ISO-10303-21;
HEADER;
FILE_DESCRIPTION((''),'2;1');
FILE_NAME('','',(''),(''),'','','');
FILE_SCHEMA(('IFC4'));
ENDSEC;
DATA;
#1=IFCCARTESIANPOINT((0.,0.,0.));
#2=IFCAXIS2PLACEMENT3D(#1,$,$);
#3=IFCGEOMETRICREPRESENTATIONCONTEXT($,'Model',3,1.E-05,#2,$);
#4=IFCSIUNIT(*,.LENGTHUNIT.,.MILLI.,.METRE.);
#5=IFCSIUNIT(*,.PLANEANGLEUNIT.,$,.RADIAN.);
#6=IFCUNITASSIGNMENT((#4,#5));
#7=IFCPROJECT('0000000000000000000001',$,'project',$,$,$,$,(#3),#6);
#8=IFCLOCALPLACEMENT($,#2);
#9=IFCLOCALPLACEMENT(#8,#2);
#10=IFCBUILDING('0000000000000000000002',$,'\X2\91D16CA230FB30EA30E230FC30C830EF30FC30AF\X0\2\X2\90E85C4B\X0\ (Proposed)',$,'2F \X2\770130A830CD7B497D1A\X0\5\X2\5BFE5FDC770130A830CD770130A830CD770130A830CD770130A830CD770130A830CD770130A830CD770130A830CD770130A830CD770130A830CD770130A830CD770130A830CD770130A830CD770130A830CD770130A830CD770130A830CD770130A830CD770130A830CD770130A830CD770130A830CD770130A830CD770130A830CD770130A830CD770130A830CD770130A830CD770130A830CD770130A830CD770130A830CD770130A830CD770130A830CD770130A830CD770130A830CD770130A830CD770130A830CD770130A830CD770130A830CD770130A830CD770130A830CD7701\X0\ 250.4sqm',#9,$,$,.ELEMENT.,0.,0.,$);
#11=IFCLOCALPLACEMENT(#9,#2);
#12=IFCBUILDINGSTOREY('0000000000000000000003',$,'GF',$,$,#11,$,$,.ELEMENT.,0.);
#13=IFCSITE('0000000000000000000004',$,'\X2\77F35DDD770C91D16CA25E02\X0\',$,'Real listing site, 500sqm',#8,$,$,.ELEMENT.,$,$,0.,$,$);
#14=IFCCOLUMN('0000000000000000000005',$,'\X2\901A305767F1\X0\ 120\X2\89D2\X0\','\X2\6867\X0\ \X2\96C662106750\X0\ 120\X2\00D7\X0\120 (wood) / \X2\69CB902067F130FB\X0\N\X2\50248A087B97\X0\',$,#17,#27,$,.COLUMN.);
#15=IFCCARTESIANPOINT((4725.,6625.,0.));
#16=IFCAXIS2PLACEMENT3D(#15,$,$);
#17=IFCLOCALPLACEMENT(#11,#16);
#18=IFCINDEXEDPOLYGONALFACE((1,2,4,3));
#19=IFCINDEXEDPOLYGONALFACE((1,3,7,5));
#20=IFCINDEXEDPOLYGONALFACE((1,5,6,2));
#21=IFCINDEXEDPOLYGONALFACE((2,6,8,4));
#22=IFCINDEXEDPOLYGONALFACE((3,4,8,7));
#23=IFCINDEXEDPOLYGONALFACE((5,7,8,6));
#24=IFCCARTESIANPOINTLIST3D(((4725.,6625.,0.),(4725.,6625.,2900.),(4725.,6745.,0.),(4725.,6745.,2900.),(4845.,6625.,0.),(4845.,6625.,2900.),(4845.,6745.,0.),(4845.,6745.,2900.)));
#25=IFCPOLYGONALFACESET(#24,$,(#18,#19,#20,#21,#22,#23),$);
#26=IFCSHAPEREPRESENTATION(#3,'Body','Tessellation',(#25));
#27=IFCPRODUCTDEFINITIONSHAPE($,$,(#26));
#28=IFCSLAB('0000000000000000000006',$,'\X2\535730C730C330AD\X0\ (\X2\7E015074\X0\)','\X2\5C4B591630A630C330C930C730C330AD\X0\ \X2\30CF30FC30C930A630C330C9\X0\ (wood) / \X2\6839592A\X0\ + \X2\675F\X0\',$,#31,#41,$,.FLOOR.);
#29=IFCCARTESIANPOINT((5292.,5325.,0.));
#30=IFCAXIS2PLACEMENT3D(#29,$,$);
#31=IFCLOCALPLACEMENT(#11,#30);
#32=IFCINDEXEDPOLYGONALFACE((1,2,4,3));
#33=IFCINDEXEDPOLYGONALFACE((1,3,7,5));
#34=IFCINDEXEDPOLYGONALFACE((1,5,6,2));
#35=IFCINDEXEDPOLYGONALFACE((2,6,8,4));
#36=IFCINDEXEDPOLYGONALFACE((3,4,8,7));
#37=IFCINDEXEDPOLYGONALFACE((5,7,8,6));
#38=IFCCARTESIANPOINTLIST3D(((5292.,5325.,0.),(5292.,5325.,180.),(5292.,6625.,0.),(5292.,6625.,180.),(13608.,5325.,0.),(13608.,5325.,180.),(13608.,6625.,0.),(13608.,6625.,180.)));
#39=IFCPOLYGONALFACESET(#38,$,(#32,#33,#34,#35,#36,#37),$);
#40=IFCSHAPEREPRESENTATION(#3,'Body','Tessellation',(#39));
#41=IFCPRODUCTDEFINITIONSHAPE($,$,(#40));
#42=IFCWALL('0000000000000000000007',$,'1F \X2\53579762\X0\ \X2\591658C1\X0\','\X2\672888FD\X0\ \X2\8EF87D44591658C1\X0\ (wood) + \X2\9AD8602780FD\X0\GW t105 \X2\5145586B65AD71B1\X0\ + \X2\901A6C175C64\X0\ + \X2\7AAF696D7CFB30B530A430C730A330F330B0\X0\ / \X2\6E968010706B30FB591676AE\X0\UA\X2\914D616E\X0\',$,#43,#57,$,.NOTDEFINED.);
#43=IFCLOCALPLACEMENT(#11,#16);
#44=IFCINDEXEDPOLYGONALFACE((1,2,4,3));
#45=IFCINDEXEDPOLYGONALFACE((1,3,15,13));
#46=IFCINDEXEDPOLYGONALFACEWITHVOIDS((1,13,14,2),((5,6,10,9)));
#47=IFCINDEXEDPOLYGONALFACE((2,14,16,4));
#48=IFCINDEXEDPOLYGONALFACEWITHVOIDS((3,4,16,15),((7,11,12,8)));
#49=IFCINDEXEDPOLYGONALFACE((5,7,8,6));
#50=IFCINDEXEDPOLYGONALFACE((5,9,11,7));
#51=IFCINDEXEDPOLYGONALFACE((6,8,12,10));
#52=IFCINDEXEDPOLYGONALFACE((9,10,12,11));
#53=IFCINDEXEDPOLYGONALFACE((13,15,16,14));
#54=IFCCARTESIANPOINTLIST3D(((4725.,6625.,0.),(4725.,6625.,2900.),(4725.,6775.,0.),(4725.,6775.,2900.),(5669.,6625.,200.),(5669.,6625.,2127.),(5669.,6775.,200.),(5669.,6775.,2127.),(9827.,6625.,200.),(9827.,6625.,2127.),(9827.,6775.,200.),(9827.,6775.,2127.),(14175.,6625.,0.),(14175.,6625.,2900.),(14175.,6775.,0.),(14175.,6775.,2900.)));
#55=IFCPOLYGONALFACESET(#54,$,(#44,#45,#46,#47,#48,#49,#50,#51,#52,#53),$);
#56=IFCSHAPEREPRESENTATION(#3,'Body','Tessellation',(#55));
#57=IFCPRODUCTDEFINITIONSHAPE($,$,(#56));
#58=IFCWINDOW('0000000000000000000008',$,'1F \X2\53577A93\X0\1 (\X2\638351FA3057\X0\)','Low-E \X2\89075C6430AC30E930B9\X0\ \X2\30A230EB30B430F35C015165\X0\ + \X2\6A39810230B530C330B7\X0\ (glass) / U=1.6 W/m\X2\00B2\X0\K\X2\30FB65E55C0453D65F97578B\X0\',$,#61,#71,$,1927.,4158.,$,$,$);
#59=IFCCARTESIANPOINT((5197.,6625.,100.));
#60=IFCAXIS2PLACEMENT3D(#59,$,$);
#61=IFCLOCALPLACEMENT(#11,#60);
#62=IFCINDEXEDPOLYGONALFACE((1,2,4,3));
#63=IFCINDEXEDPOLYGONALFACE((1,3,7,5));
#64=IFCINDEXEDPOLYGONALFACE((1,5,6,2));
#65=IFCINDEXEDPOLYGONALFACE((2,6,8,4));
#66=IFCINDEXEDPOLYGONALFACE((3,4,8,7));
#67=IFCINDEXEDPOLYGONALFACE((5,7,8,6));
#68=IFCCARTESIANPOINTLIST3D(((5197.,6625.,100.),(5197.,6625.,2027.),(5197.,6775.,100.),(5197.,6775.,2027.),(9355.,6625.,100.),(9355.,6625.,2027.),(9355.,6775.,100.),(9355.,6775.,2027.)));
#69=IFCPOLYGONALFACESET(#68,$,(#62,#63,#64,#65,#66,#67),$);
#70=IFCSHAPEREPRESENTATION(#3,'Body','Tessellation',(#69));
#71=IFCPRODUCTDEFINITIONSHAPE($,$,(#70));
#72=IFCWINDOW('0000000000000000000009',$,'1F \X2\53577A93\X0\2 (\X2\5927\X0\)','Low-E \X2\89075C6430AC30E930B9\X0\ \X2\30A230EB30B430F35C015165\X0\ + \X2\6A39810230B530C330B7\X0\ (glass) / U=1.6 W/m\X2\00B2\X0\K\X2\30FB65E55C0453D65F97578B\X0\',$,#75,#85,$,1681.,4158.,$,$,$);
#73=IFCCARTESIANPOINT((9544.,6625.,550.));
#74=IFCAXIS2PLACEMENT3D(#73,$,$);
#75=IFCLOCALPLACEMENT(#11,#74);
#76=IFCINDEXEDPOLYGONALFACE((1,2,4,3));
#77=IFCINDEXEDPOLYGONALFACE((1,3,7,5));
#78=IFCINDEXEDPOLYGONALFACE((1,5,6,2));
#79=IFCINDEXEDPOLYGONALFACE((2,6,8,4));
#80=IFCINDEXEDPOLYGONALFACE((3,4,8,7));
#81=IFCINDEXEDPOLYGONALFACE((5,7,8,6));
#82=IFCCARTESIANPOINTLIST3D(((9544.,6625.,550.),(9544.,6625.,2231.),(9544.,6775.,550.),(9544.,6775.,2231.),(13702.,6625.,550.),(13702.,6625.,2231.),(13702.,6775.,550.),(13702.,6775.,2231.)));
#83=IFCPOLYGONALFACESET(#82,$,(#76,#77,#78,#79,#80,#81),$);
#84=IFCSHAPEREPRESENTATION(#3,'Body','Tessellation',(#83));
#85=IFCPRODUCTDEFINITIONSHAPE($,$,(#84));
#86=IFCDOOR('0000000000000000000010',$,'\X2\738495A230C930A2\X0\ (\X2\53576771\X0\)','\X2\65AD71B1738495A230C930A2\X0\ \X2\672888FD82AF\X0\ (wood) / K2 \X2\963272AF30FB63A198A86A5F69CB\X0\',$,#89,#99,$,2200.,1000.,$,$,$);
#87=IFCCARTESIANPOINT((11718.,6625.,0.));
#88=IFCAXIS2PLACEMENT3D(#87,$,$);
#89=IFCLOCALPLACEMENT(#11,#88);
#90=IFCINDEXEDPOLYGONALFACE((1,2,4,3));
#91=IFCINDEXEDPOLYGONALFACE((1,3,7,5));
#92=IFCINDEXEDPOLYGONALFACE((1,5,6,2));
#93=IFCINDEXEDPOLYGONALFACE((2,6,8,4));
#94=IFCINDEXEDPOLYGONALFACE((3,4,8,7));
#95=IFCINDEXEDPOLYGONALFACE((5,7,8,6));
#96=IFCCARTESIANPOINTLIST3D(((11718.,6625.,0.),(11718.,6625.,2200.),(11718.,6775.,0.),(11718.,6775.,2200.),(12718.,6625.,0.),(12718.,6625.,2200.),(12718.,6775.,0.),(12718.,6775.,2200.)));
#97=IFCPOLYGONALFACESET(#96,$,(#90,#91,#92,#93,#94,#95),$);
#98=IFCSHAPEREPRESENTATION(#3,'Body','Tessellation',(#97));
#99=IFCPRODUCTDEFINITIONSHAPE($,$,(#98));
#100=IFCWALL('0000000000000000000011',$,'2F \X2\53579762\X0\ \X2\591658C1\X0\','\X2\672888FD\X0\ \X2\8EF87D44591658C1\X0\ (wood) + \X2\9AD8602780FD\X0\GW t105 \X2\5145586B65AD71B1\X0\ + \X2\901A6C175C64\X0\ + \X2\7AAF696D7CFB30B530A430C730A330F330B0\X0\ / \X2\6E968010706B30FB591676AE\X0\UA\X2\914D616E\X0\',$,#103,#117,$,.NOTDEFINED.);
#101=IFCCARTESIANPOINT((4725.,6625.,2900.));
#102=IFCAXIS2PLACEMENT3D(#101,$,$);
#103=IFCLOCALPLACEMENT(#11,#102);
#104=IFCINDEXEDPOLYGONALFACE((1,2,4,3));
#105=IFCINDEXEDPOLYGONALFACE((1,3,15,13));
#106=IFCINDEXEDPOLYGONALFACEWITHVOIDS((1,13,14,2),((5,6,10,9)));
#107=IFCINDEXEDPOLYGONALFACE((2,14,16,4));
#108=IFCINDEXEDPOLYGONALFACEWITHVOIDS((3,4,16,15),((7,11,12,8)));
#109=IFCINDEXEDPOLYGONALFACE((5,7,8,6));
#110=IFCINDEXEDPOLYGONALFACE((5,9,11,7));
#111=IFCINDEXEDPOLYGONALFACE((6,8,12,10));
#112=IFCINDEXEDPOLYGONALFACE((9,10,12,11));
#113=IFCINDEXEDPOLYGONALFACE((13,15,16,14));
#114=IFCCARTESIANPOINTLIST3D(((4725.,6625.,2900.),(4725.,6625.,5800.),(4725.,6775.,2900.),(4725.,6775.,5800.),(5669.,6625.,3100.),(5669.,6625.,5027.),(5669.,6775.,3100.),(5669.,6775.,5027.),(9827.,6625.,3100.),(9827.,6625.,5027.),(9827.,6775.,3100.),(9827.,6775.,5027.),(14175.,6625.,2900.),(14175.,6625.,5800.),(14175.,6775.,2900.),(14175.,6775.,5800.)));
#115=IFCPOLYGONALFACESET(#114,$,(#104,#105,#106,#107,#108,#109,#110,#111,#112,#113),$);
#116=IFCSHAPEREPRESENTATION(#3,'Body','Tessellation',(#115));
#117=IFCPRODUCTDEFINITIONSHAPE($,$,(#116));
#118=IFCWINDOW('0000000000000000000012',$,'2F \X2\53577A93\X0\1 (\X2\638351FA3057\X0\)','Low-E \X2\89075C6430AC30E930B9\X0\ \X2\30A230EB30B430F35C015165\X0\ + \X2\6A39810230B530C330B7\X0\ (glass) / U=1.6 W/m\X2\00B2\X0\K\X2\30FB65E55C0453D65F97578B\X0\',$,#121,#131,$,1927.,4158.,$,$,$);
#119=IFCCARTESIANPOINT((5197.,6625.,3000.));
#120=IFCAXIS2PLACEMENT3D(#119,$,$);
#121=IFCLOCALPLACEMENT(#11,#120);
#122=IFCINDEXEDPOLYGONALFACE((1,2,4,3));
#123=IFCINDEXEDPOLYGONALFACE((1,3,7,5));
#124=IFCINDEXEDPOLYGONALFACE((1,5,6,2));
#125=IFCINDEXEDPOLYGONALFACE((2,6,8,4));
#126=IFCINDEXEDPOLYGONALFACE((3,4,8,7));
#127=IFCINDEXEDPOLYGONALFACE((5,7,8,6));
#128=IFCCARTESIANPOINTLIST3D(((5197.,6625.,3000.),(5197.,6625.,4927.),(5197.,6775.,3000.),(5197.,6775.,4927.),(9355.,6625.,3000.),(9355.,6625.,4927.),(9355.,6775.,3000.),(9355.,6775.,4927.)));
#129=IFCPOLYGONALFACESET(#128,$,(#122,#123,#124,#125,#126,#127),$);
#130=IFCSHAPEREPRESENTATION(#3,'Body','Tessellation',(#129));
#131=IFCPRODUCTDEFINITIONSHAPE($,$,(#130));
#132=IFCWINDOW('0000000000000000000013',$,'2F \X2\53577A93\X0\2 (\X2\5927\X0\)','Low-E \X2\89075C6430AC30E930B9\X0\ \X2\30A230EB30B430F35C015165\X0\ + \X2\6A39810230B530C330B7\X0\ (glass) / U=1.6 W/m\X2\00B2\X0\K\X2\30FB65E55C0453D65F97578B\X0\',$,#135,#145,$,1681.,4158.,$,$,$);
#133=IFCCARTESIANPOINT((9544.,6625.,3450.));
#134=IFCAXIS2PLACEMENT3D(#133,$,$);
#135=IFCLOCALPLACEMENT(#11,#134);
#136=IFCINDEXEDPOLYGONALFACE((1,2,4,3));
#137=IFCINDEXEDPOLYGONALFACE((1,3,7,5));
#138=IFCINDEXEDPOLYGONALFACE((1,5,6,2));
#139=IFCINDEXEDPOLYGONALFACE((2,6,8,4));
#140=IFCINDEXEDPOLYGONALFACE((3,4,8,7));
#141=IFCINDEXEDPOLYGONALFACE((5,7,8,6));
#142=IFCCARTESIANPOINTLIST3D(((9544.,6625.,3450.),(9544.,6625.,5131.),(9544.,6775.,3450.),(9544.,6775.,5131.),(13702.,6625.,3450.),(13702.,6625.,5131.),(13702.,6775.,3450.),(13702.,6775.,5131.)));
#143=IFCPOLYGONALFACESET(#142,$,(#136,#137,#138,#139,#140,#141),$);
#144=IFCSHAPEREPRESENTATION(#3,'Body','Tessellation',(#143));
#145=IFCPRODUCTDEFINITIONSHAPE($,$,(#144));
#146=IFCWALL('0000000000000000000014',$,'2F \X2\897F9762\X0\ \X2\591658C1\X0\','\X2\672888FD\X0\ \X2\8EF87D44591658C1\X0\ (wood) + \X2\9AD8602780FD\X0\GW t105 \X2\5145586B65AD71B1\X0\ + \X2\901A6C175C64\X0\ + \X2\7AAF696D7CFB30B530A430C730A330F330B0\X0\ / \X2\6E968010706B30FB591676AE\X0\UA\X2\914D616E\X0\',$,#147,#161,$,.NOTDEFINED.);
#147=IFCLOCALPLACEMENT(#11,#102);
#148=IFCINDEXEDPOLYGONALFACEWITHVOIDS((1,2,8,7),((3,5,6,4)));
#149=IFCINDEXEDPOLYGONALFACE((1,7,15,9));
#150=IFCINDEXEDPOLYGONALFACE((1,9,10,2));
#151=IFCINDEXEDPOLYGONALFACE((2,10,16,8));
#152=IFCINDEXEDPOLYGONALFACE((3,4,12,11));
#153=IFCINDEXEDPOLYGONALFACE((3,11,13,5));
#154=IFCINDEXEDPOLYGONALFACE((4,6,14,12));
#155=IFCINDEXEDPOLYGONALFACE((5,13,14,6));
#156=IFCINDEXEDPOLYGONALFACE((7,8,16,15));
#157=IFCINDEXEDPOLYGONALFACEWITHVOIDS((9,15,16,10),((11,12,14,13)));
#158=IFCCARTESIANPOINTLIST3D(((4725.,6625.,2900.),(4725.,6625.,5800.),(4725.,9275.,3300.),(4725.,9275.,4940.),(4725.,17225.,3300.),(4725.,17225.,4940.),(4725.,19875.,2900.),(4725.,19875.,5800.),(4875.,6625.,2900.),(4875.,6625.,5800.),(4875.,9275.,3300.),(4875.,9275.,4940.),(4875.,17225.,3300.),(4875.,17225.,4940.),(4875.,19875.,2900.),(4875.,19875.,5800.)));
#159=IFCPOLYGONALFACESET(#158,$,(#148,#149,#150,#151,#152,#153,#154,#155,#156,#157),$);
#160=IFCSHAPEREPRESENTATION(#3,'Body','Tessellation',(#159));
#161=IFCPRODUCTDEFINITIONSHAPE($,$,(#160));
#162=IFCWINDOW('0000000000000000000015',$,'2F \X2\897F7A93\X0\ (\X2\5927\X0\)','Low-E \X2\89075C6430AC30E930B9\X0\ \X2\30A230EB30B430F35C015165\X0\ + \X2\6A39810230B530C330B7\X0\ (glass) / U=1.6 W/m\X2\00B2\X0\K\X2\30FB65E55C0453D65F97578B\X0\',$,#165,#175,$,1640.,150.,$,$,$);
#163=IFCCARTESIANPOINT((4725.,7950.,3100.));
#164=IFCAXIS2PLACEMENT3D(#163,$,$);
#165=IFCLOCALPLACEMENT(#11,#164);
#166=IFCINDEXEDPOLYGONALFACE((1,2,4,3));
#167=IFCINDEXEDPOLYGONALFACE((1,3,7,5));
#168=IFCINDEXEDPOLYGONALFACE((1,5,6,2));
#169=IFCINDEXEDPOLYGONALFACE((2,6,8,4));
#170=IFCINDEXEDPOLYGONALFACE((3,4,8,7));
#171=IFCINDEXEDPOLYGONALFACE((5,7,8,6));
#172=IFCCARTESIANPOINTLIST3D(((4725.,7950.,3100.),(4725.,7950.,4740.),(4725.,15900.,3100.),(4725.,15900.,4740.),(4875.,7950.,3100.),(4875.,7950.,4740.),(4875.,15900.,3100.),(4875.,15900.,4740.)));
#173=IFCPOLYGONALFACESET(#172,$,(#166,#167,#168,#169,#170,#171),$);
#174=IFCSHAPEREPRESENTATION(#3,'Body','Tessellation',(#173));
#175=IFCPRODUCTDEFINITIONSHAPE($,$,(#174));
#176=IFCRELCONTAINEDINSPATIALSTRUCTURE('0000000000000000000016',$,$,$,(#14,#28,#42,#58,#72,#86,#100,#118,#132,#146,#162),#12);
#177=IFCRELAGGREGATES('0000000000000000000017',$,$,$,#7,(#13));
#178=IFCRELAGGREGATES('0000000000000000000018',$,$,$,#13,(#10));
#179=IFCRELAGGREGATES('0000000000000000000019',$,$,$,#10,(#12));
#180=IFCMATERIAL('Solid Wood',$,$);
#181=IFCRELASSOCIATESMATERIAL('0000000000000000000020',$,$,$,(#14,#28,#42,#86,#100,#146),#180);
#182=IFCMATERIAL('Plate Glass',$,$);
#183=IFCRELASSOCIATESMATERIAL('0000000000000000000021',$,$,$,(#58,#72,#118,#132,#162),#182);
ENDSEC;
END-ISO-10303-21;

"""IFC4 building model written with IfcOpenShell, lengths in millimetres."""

from ifc_helpers import new_model, si_unit, frame, frame_2d, origin, place, context, project, spatial, rectangle, extrude, material, element, fill, save


model = new_model("IFC4")

# Units and contexts
model_context = context("Model", 3, precision=1e-05, world=origin())
ifc_project = project(units=[si_unit("LENGTHUNIT", "METRE", prefix="MILLI"), si_unit("PLANEANGLEUNIT", "RADIAN")], contexts=[model_context])

# Site, building, storey
site_placement = place(None, origin())
site = spatial("IfcSite", under=ifc_project, at=site_placement, Name="石川県金沢市", ObjectType="Real listing site, 500sqm", CompositionType="ELEMENT", RefElevation=0.0)
building_placement = place(site_placement, origin())
building = spatial("IfcBuilding", under=site, at=building_placement, Name="金沢・リモートワーク2部屋 (Proposed)", ObjectType="2F 省エネ等級5対応省エネ省エネ省エネ省エネ省エネ省エネ省エネ省エネ省エネ省エネ省エネ省エネ省エネ省エネ省エネ省エネ省エネ省エネ省エネ省エネ省エネ省エネ省エネ省エネ省エネ省エネ省エネ省エネ省エネ省エネ省エネ省エネ省エネ省エネ省エネ省エネ省エネ省 250.4sqm", CompositionType="ELEMENT", ElevationOfRefHeight=0.0, ElevationOfTerrain=0.0)
storey_placement = place(building_placement, origin())
storey = spatial("IfcBuildingStorey", under=building, at=storey_placement, Name="GF", CompositionType="ELEMENT", Elevation=0.0)

# Column
ifc_material_1 = material(Name="Solid Wood")
column_placement = place(storey_placement, frame((4725.0, 6625.0, 0.0)))
element("IfcColumn", 1, at=column_placement, inside=storey, material=ifc_material_1, Name="通し柱 120角", Description="桧 集成材 120×120 (wood) / 構造柱・N値計算", PredefinedType="COLUMN", context=model_context, shape_type="SweptSolid", body=[
    extrude(rectangle(XDim=120.0, YDim=120.0, at=frame_2d((60.0, 60.0))), frame((4725.0, 6625.0, 0.0)), (0.0, 0.0, 1.0), 2900.0),
])

# Slab
slab_1_placement = place(storey_placement, frame((5292.0, 5325.0, 0.0)))
element("IfcSlab", 2, at=slab_1_placement, inside=storey, material=ifc_material_1, Name="南デッキ (縁側)", Description="屋外ウッドデッキ ハードウッド (wood) / 根太 + 束", PredefinedType="FLOOR", context=model_context, shape_type="SweptSolid", body=[
    extrude(rectangle(XDim=8316.0, YDim=1300.0, at=frame_2d((4158.0, 650.0))), frame((5292.0, 5325.0, 0.0)), (0.0, 0.0, 1.0), 180.0),
])

# Wall, openings, windows, door
wall_1_placement = place(storey_placement, frame((4725.0, 6625.0, 0.0)))
wall_1 = element("IfcWall", 3, at=wall_1_placement, inside=storey, material=ifc_material_1, Name="1F 南面 外壁", Description="木製 軸組外壁 (wood) + 高性能GW t105 充填断熱 + 通気層 + 窯業系サイディング / 準耐火・外皮UA配慮", PredefinedType="NOTDEFINED", context=model_context, shape_type="SweptSolid", body=[
    extrude(rectangle(XDim=9450.0, YDim=150.0, at=frame_2d((4725.0, 75.0))), frame((4725.0, 6625.0, 0.0)), (0.0, 0.0, 1.0), 2900.0),
])
opening_1_placement = place(storey_placement, frame((5197.0, 6625.0, 100.0)))
opening_1 = element("IfcOpeningElement", 4, at=opening_1_placement, cuts=wall_1, PredefinedType="NOTDEFINED", context=model_context, shape_type="SweptSolid", body=[
    extrude(rectangle(XDim=4158.0, YDim=150.0, at=frame_2d((2079.0, 75.0))), frame((5197.0, 6625.0, 100.0)), (0.0, 0.0, 1.0), 1927.0),
])
opening_2_placement = place(storey_placement, frame((9544.0, 6625.0, 550.0)))
opening_2 = element("IfcOpeningElement", 5, at=opening_2_placement, cuts=wall_1, PredefinedType="NOTDEFINED", context=model_context, shape_type="SweptSolid", body=[
    extrude(rectangle(XDim=4158.0, YDim=150.0, at=frame_2d((2079.0, 75.0))), frame((9544.0, 6625.0, 550.0)), (0.0, 0.0, 1.0), 1681.0),
])
opening_3_placement = place(storey_placement, frame((11718.0, 6625.0, 0.0)))
opening_3 = element("IfcOpeningElement", 6, at=opening_3_placement, cuts=wall_1, PredefinedType="NOTDEFINED", context=model_context, shape_type="SweptSolid", body=[
    extrude(rectangle(XDim=1000.0, YDim=150.0, at=frame_2d((500.0, 75.0))), frame((11718.0, 6625.0, 0.0)), (0.0, 0.0, 1.0), 2200.0),
])
ifc_material_2 = material(Name="Plate Glass")
window_1_placement = place(storey_placement, frame((5197.0, 6625.0, 100.0)))
window_1 = element("IfcWindow", 7, at=window_1_placement, inside=storey, material=ifc_material_2, Name="1F 南窓1 (掃出し)", Description="Low-E 複層ガラス アルゴン封入 + 樹脂サッシ (glass) / U=1.6 W/m²K・日射取得型", OverallHeight=1927.0, OverallWidth=4158.0, context=model_context, shape_type="SweptSolid", body=[
    extrude(rectangle(XDim=4158.0, YDim=150.0, at=frame_2d((2079.0, 75.0))), frame((5197.0, 6625.0, 100.0)), (0.0, 0.0, 1.0), 1927.0),
])
fill(opening_1, window_1)
window_2_placement = place(storey_placement, frame((9544.0, 6625.0, 550.0)))
window_2 = element("IfcWindow", 8, at=window_2_placement, inside=storey, material=ifc_material_2, Name="1F 南窓2 (大)", Description="Low-E 複層ガラス アルゴン封入 + 樹脂サッシ (glass) / U=1.6 W/m²K・日射取得型", OverallHeight=1681.0, OverallWidth=4158.0, context=model_context, shape_type="SweptSolid", body=[
    extrude(rectangle(XDim=4158.0, YDim=150.0, at=frame_2d((2079.0, 75.0))), frame((9544.0, 6625.0, 550.0)), (0.0, 0.0, 1.0), 1681.0),
])
fill(opening_2, window_2)
door_placement = place(storey_placement, frame((11718.0, 6625.0, 0.0)))
door = element("IfcDoor", 9, at=door_placement, inside=storey, material=ifc_material_1, Name="玄関ドア (南東)", Description="断熱玄関ドア 木製芯 (wood) / K2 防犯・採風機構", OverallHeight=2200.0, OverallWidth=1000.0, context=model_context, shape_type="SweptSolid", body=[
    extrude(rectangle(XDim=1000.0, YDim=150.0, at=frame_2d((500.0, 75.0))), frame((11718.0, 6625.0, 0.0)), (0.0, 0.0, 1.0), 2200.0),
])
fill(opening_3, door)

# Wall, openings, windows
wall_2_placement = place(storey_placement, frame((4725.0, 6625.0, 2900.0)))
wall_2 = element("IfcWall", 10, at=wall_2_placement, inside=storey, material=ifc_material_1, Name="2F 南面 外壁", Description="木製 軸組外壁 (wood) + 高性能GW t105 充填断熱 + 通気層 + 窯業系サイディング / 準耐火・外皮UA配慮", PredefinedType="NOTDEFINED", context=model_context, shape_type="SweptSolid", body=[
    extrude(rectangle(XDim=9450.0, YDim=150.0, at=frame_2d((4725.0, 75.0))), frame((4725.0, 6625.0, 2900.0)), (0.0, 0.0, 1.0), 2900.0),
])
opening_4_placement = place(storey_placement, frame((5197.0, 6625.0, 3000.0)))
opening_4 = element("IfcOpeningElement", 11, at=opening_4_placement, cuts=wall_2, PredefinedType="NOTDEFINED", context=model_context, shape_type="SweptSolid", body=[
    extrude(rectangle(XDim=4158.0, YDim=150.0, at=frame_2d((2079.0, 75.0))), frame((5197.0, 6625.0, 3000.0)), (0.0, 0.0, 1.0), 1927.0),
])
opening_5_placement = place(storey_placement, frame((9544.0, 6625.0, 3450.0)))
opening_5 = element("IfcOpeningElement", 12, at=opening_5_placement, cuts=wall_2, PredefinedType="NOTDEFINED", context=model_context, shape_type="SweptSolid", body=[
    extrude(rectangle(XDim=4158.0, YDim=150.0, at=frame_2d((2079.0, 75.0))), frame((9544.0, 6625.0, 3450.0)), (0.0, 0.0, 1.0), 1681.0),
])
window_3_placement = place(storey_placement, frame((5197.0, 6625.0, 3000.0)))
window_3 = element("IfcWindow", 13, at=window_3_placement, inside=storey, material=ifc_material_2, Name="2F 南窓1 (掃出し)", Description="Low-E 複層ガラス アルゴン封入 + 樹脂サッシ (glass) / U=1.6 W/m²K・日射取得型", OverallHeight=1927.0, OverallWidth=4158.0, context=model_context, shape_type="SweptSolid", body=[
    extrude(rectangle(XDim=4158.0, YDim=150.0, at=frame_2d((2079.0, 75.0))), frame((5197.0, 6625.0, 3000.0)), (0.0, 0.0, 1.0), 1927.0),
])
fill(opening_4, window_3)
window_4_placement = place(storey_placement, frame((9544.0, 6625.0, 3450.0)))
window_4 = element("IfcWindow", 14, at=window_4_placement, inside=storey, material=ifc_material_2, Name="2F 南窓2 (大)", Description="Low-E 複層ガラス アルゴン封入 + 樹脂サッシ (glass) / U=1.6 W/m²K・日射取得型", OverallHeight=1681.0, OverallWidth=4158.0, context=model_context, shape_type="SweptSolid", body=[
    extrude(rectangle(XDim=4158.0, YDim=150.0, at=frame_2d((2079.0, 75.0))), frame((9544.0, 6625.0, 3450.0)), (0.0, 0.0, 1.0), 1681.0),
])
fill(opening_5, window_4)

# Wall, opening, window
wall_3_placement = place(storey_placement, frame((4725.0, 6625.0, 2900.0)))
wall_3 = element("IfcWall", 15, at=wall_3_placement, inside=storey, material=ifc_material_1, Name="2F 西面 外壁", Description="木製 軸組外壁 (wood) + 高性能GW t105 充填断熱 + 通気層 + 窯業系サイディング / 準耐火・外皮UA配慮", PredefinedType="NOTDEFINED", context=model_context, shape_type="SweptSolid", body=[
    extrude(rectangle(XDim=150.0, YDim=13250.0, at=frame_2d((75.0, 6625.0))), frame((4725.0, 6625.0, 2900.0)), (0.0, 0.0, 1.0), 2900.0),
])
opening_6_placement = place(storey_placement, frame((4725.0, 7950.0, 3100.0)))
opening_6 = element("IfcOpeningElement", 16, at=opening_6_placement, cuts=wall_3, PredefinedType="NOTDEFINED", context=model_context, shape_type="SweptSolid", body=[
    extrude(rectangle(XDim=150.0, YDim=7950.0, at=frame_2d((75.0, 3975.0))), frame((4725.0, 7950.0, 3100.0)), (0.0, 0.0, 1.0), 1640.0),
])
window_5_placement = place(storey_placement, frame((4725.0, 7950.0, 3100.0)))
window_5 = element("IfcWindow", 17, at=window_5_placement, inside=storey, material=ifc_material_2, Name="2F 西窓 (大)", Description="Low-E 複層ガラス アルゴン封入 + 樹脂サッシ (glass) / U=1.6 W/m²K・日射取得型", OverallHeight=1640.0, OverallWidth=150.0, context=model_context, shape_type="SweptSolid", body=[
    extrude(rectangle(XDim=150.0, YDim=7950.0, at=frame_2d((75.0, 3975.0))), frame((4725.0, 7950.0, 3100.0)), (0.0, 0.0, 1.0), 1640.0),
])
fill(opening_6, window_5)

save(model, "model.ifc")
